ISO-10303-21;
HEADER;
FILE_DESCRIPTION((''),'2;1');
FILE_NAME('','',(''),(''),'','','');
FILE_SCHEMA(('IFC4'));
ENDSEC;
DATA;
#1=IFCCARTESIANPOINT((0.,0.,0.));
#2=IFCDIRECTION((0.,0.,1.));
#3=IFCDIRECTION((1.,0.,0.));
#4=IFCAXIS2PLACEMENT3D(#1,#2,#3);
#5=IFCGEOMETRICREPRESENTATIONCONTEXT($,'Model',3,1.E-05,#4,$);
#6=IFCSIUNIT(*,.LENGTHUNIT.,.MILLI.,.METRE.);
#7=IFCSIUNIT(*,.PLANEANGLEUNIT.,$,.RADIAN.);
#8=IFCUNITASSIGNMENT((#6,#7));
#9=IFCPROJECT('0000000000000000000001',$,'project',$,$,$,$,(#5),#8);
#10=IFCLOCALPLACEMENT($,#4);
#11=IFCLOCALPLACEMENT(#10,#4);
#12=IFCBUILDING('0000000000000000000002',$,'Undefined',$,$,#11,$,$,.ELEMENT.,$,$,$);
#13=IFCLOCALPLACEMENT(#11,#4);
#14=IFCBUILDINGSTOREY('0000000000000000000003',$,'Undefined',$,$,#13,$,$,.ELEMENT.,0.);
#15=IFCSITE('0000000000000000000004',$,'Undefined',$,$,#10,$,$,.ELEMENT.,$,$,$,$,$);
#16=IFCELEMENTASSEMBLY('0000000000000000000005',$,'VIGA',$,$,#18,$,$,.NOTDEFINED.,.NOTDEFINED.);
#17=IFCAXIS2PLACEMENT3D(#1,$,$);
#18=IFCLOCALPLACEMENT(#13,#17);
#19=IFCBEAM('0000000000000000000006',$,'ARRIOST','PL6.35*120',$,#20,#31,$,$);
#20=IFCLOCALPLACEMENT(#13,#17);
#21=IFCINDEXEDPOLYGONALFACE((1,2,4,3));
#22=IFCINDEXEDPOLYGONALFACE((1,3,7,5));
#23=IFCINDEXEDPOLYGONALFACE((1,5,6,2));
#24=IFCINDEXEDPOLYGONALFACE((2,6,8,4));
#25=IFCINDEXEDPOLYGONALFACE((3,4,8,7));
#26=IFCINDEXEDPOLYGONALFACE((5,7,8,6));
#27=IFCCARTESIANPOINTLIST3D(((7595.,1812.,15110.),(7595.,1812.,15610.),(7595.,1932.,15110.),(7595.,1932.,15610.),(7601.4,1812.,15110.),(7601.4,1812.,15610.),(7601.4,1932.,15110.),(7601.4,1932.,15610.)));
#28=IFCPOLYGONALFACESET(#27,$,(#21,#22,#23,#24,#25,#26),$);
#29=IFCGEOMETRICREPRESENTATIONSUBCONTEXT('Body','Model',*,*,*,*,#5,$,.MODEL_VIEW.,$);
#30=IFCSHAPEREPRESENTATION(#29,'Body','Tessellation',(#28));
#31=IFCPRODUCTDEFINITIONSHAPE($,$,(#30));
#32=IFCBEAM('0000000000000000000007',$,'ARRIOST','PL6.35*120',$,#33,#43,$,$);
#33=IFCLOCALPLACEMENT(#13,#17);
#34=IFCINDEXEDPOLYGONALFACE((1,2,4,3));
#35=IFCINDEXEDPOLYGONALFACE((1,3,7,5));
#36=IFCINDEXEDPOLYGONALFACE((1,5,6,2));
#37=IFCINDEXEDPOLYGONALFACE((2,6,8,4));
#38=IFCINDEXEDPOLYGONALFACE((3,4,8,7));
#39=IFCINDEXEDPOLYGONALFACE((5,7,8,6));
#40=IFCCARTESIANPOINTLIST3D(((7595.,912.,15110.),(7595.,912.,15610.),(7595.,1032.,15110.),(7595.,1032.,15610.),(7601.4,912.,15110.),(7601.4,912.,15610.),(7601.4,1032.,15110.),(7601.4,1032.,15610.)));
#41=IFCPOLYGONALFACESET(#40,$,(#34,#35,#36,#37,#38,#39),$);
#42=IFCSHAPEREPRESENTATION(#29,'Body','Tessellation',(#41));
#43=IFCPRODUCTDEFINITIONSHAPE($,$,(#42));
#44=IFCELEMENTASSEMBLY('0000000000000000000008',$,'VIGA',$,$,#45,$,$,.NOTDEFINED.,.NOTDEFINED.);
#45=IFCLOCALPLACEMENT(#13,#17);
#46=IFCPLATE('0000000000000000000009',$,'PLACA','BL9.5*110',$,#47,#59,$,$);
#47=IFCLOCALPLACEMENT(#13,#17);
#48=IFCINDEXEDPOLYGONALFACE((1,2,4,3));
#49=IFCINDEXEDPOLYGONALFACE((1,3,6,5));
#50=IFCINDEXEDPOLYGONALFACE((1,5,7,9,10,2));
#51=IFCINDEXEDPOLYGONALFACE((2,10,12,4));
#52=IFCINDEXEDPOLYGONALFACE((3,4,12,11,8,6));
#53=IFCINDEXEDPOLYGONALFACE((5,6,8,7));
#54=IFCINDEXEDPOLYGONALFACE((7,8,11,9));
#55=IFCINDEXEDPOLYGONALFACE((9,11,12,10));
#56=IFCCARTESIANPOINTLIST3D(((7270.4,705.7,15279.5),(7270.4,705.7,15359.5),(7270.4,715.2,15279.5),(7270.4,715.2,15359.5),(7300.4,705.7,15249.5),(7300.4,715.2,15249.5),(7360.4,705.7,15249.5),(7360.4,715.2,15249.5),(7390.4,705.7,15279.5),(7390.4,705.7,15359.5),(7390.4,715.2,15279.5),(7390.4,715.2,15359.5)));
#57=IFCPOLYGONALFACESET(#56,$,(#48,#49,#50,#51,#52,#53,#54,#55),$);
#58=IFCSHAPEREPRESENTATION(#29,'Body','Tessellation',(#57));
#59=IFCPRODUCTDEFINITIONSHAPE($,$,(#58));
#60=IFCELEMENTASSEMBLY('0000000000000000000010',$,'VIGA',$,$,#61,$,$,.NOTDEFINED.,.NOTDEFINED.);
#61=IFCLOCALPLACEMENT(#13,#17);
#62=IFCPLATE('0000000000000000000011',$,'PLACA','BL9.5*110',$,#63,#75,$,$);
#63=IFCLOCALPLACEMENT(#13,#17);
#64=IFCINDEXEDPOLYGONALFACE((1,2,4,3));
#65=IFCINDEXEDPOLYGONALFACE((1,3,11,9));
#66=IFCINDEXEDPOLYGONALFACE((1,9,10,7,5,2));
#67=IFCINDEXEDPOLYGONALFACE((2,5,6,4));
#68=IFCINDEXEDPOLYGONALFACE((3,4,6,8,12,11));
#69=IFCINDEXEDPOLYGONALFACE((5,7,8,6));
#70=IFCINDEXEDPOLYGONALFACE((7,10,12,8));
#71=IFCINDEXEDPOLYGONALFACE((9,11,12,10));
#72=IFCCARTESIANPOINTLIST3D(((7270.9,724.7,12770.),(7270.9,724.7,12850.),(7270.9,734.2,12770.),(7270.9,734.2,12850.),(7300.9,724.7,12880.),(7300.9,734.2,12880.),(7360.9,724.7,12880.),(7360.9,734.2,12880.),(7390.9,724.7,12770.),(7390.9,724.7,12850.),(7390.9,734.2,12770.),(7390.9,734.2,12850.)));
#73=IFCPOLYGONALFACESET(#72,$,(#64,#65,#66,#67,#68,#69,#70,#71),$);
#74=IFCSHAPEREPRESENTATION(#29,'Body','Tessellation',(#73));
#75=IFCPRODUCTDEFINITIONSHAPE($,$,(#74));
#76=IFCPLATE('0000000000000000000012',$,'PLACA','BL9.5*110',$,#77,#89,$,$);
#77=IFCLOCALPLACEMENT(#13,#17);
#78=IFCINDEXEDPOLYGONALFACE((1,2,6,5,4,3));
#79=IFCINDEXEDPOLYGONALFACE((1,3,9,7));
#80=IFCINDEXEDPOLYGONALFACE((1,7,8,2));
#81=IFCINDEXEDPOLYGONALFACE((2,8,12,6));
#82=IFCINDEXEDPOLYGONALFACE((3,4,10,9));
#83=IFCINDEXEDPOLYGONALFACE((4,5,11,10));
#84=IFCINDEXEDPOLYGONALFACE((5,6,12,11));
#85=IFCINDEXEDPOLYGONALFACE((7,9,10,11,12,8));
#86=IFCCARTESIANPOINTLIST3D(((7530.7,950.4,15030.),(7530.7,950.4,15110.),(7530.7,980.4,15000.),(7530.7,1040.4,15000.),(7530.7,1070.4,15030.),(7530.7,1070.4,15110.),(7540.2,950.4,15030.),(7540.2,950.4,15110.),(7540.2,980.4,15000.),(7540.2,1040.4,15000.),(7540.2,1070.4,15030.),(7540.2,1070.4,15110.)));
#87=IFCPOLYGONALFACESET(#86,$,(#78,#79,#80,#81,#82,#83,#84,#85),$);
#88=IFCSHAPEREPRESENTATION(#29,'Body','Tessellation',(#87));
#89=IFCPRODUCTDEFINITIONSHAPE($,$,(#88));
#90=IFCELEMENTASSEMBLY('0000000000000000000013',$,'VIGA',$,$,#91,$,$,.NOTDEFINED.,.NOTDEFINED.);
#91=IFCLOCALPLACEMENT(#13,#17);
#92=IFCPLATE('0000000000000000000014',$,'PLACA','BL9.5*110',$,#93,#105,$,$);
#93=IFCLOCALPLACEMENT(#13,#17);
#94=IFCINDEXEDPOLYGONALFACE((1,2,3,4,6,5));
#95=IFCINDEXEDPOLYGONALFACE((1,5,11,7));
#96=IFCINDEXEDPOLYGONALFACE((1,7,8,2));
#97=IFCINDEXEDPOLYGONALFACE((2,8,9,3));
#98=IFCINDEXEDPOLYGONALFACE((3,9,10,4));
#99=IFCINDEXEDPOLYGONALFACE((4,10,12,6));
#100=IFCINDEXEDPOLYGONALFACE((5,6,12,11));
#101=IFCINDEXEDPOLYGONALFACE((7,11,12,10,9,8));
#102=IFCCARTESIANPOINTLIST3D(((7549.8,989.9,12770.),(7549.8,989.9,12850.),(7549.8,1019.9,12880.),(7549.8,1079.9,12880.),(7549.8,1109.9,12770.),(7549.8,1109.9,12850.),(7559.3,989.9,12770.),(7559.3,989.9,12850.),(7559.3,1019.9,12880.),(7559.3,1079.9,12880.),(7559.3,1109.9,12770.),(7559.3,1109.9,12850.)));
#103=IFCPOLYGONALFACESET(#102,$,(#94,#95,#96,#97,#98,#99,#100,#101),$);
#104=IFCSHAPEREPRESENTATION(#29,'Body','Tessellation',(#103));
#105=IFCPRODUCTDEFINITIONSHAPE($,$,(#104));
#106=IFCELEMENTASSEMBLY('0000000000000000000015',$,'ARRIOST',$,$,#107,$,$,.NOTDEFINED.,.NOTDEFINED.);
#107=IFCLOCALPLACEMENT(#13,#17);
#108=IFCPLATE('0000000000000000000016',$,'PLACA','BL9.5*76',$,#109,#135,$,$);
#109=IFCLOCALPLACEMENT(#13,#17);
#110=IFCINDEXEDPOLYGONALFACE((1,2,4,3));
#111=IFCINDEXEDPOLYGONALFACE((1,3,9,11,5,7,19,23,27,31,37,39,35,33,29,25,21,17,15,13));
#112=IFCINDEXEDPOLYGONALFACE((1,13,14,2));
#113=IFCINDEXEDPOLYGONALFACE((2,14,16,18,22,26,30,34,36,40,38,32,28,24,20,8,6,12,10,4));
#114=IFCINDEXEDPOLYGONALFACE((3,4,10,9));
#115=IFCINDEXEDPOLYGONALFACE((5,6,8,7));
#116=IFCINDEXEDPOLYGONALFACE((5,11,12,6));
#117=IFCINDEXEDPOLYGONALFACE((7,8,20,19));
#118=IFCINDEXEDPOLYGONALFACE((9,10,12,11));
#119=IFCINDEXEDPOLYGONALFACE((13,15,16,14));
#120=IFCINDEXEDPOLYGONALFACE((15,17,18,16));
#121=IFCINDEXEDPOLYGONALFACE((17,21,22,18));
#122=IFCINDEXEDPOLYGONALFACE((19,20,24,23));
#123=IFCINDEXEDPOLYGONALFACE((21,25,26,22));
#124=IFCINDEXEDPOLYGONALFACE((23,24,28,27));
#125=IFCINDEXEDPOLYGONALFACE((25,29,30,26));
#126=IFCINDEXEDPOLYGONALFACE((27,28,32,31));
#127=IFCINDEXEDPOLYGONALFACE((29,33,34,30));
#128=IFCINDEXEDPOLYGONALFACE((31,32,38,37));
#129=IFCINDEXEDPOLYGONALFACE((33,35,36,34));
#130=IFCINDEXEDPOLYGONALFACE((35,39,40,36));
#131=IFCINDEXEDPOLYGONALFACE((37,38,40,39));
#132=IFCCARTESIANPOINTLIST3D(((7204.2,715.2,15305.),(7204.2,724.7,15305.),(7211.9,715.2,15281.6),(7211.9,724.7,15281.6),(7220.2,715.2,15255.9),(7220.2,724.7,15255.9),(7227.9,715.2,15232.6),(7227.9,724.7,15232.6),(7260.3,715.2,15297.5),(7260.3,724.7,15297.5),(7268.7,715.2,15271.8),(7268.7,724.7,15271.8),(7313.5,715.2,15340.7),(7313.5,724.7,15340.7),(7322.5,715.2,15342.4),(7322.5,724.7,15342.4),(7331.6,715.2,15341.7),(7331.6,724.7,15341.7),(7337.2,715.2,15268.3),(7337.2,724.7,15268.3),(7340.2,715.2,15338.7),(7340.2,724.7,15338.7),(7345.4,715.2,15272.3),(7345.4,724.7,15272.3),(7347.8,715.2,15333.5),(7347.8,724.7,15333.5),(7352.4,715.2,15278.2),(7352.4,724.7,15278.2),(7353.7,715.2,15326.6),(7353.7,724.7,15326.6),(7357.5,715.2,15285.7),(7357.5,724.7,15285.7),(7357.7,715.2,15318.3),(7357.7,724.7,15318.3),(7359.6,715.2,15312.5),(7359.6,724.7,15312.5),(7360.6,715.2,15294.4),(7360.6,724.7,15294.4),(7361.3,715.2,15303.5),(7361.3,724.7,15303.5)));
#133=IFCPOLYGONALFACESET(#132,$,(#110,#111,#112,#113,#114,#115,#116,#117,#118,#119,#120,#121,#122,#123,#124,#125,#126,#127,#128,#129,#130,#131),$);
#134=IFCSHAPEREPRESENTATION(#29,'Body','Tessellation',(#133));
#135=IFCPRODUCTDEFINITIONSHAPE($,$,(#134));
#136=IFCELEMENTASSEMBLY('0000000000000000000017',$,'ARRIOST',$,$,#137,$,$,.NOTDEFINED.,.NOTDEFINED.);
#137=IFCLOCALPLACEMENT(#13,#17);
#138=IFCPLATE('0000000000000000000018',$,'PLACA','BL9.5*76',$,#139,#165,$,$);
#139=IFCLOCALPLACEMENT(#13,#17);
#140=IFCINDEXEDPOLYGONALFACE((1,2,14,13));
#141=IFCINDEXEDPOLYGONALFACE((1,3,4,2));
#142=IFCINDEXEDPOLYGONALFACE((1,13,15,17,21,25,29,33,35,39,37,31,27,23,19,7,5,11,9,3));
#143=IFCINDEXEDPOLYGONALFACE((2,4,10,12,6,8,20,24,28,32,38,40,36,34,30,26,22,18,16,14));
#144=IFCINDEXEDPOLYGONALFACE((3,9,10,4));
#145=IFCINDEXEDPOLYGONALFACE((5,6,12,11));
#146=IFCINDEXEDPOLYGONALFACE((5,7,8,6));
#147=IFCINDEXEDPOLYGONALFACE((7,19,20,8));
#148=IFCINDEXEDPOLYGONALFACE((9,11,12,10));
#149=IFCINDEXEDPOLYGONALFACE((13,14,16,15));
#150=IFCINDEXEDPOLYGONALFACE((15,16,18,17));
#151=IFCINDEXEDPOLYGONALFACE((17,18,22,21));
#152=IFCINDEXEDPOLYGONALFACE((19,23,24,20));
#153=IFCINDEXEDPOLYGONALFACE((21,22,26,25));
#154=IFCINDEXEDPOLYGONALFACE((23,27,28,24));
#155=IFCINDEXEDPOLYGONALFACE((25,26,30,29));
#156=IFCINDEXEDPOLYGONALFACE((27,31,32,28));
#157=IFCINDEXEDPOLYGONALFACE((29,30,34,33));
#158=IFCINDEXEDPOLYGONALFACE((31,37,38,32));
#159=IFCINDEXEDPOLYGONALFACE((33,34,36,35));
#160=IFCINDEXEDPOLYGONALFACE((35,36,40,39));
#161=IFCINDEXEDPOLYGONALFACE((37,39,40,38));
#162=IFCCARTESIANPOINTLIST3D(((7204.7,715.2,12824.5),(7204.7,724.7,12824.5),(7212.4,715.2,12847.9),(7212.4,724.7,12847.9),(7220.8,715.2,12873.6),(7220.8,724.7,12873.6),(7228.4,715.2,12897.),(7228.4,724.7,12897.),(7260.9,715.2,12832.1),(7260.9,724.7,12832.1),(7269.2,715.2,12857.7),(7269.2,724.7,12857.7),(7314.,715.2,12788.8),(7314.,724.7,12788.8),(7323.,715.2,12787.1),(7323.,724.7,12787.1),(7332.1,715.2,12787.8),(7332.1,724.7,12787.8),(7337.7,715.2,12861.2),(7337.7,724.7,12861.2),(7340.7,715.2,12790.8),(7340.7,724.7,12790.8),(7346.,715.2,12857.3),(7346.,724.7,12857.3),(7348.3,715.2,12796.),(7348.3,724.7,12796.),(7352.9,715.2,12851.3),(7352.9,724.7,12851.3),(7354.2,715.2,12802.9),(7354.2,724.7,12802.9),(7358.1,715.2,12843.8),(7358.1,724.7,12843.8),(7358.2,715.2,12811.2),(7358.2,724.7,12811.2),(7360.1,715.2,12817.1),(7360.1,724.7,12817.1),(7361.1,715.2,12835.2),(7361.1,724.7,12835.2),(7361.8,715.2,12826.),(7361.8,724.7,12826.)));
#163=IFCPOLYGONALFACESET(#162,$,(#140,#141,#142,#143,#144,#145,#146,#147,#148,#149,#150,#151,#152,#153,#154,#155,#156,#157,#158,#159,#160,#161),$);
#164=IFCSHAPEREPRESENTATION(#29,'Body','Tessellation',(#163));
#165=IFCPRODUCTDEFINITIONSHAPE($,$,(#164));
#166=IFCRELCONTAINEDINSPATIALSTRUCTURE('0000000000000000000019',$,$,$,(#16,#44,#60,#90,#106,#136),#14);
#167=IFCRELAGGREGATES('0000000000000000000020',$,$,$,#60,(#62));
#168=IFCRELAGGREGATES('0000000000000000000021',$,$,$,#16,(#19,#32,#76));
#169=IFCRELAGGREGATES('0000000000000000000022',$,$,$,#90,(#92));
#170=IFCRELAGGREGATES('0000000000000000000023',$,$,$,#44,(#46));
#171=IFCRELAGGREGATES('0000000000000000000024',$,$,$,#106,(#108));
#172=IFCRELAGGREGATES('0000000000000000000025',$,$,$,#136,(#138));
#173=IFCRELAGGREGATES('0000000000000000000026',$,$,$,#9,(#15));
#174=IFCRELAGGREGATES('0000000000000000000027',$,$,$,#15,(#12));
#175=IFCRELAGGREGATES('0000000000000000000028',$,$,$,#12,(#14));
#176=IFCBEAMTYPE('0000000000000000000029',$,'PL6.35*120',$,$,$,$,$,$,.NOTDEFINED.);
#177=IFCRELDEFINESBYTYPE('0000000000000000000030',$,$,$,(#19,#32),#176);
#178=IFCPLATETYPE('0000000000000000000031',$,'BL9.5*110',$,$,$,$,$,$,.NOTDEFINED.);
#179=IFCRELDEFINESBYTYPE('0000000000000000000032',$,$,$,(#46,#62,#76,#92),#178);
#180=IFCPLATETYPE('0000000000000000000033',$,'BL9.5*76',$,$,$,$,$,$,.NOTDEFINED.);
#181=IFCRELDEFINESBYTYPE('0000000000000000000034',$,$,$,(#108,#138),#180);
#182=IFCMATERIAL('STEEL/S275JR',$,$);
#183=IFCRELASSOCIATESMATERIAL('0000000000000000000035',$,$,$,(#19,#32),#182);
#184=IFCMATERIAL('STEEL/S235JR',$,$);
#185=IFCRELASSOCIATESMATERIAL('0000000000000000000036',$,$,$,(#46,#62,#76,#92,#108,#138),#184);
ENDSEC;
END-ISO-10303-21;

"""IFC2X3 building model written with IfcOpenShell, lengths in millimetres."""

from ifc_helpers import new_model, si_unit, frame, frame_2d, origin_with_axes, origin_2d_with_axis, place, context, subcontext, project, spatial, polyline, circle_curve, parameter, trimmed, segment, composite_curve, rectangle, outline, extrude, boolean, material, type_object, element, aggregate, save


model = new_model("IFC2X3")

# Units and contexts
model_context = context("Model", 3, precision=1e-05, world=origin_with_axes())
body_context = subcontext(model_context, "Body", "Model", "MODEL_VIEW")
ifc_project = project(units=[si_unit("LENGTHUNIT", "METRE", prefix="MILLI"), si_unit("PLANEANGLEUNIT", "RADIAN")], contexts=[model_context])

# Site, building, storey
site_placement = place(None, origin_with_axes())
site = spatial("IfcSite", under=ifc_project, at=site_placement, Name="Undefined", CompositionType="ELEMENT")
building_placement = place(site_placement, origin_with_axes())
building = spatial("IfcBuilding", under=site, at=building_placement, Name="Undefined", CompositionType="ELEMENT")
storey_placement = place(building_placement, origin_with_axes())
storey = spatial("IfcBuildingStorey", under=building, at=storey_placement, Name="Undefined", CompositionType="ELEMENT", Elevation=0.0)

# Element assembly, beams
assembly_1_placement = place(storey_placement, origin_with_axes())
assembly_1 = element("IfcElementAssembly", 1, at=assembly_1_placement, inside=storey, Name="VIGA", AssemblyPlace="NOTDEFINED", PredefinedType="NOTDEFINED")
ifc_material_1 = material(Name="STEEL/S275JR")
beam_type = type_object("IfcBeamType", Name="PL6.35*120", PredefinedType="NOTDEFINED")
beam_1_placement = place(assembly_1_placement, frame((7598.2, 1872.0, 15110.0), z_axis=(0.0, 1.0, 0.0), x_axis=(0.0, 0.0, 1.0)))
beam_1 = element("IfcBeam", 2, at=beam_1_placement, type_object=beam_type, material=ifc_material_1, Name="ARRIOST", Description="PL6.35*120", context=body_context, shape_type="SweptSolid", body=[
    extrude(rectangle(XDim=6.3, YDim=120.0, at=origin_2d_with_axis()), frame((500.0, 0.0, 0.0), z_axis=(-1.0, 0.0, 0.0), x_axis=(0.0, -1.0, 0.0)), (0.0, 0.0, 1.0), 500.0),
])
beam_2_placement = place(assembly_1_placement, frame((7598.2, 972.0, 15110.0), z_axis=(0.0, 1.0, 0.0), x_axis=(0.0, 0.0, 1.0)))
beam_2 = element("IfcBeam", 3, at=beam_2_placement, type_object=beam_type, material=ifc_material_1, Name="ARRIOST", Description="PL6.35*120", context=body_context, shape_type="SweptSolid", body=[
    extrude(rectangle(XDim=6.3, YDim=120.0, at=origin_2d_with_axis()), frame((500.0, 0.0, 0.0), z_axis=(-1.0, 0.0, 0.0), x_axis=(0.0, -1.0, 0.0)), (0.0, 0.0, 1.0), 500.0),
])

# Element assemblies, plates
assembly_2_placement = place(storey_placement, origin_with_axes())
assembly_2 = element("IfcElementAssembly", 4, at=assembly_2_placement, inside=storey, Name="VIGA", AssemblyPlace="NOTDEFINED", PredefinedType="NOTDEFINED")
ifc_material_2 = material(Name="STEEL/S235JR")
plate_type_1 = type_object("IfcPlateType", Name="BL9.5*110", PredefinedType="NOTDEFINED")
plate_1_placement = place(assembly_2_placement, frame((7270.4, 710.5, 15279.5), z_axis=(0.0, 1.0, 0.0), x_axis=(0.0, 0.0, 1.0)))
plate_1 = element("IfcPlate", 5, at=plate_1_placement, type_object=plate_type_1, material=ifc_material_2, Name="PLACA", Description="BL9.5*110", context=body_context, shape_type="SweptSolid", body=[
    extrude(outline(polyline([(0.0, 0.0), (80.0, 0.0), (80.0, 120.0), (0.0, 120.0), (-30.0, 90.0), (-30.0, 30.0), (0.0, 0.0)])), frame((0.0, 0.0, -4.7), z_axis=(0.0, 0.0, 1.0), x_axis=(1.0, 0.0, 0.0)), (0.0, 0.0, 1.0), 9.5),
])
assembly_3_placement = place(storey_placement, origin_with_axes())
assembly_3 = element("IfcElementAssembly", 6, at=assembly_3_placement, inside=storey, Name="VIGA", AssemblyPlace="NOTDEFINED", PredefinedType="NOTDEFINED")
plate_2_placement = place(assembly_3_placement, frame((7270.9, 729.5, 12850.0), z_axis=(0.0, -1.0, 0.0), x_axis=(0.0, 0.0, -1.0)))
plate_2 = element("IfcPlate", 7, at=plate_2_placement, type_object=plate_type_1, material=ifc_material_2, Name="PLACA", Description="BL9.5*110", context=body_context, shape_type="SweptSolid", body=[
    extrude(outline(polyline([(0.0, 0.0), (80.0, 0.0), (80.0, 120.0), (0.0, 120.0), (-30.0, 90.0), (-30.0, 30.0), (0.0, 0.0)])), frame((0.0, 0.0, -4.7), z_axis=(0.0, 0.0, 1.0), x_axis=(1.0, 0.0, 0.0)), (0.0, 0.0, 1.0), 9.5),
])
aggregate(assembly_3, [plate_2])

# Plate
plate_3_placement = place(assembly_1_placement, frame((7535.5, 1070.4, 15030.0), z_axis=(1.0, 0.0, 0.0), x_axis=(0.0, 0.0, 1.0)))
plate_3 = element("IfcPlate", 8, at=plate_3_placement, type_object=plate_type_1, material=ifc_material_2, Name="PLACA", Description="BL9.5*110", context=body_context, shape_type="SweptSolid", body=[
    extrude(outline(polyline([(0.0, 0.0), (80.0, 0.0), (80.0, 120.0), (0.0, 120.0), (-30.0, 90.0), (-30.0, 30.0), (0.0, 0.0)])), frame((0.0, 0.0, -4.7), z_axis=(0.0, 0.0, 1.0), x_axis=(1.0, 0.0, 0.0)), (0.0, 0.0, 1.0), 9.5),
])
aggregate(assembly_1, [beam_1, beam_2, plate_3])

# Element assemblies, plates
assembly_4_placement = place(storey_placement, origin_with_axes())
assembly_4 = element("IfcElementAssembly", 9, at=assembly_4_placement, inside=storey, Name="VIGA", AssemblyPlace="NOTDEFINED", PredefinedType="NOTDEFINED")
plate_4_placement = place(assembly_4_placement, frame((7554.5, 1109.9, 12850.0), z_axis=(-1.0, 0.0, 0.0), x_axis=(0.0, 0.0, -1.0)))
plate_4 = element("IfcPlate", 10, at=plate_4_placement, type_object=plate_type_1, material=ifc_material_2, Name="PLACA", Description="BL9.5*110", context=body_context, shape_type="SweptSolid", body=[
    extrude(outline(polyline([(0.0, 0.0), (80.0, 0.0), (80.0, 120.0), (0.0, 120.0), (-30.0, 90.0), (-30.0, 30.0), (0.0, 0.0)])), frame((0.0, 0.0, -4.7), z_axis=(0.0, 0.0, 1.0), x_axis=(1.0, 0.0, 0.0)), (0.0, 0.0, 1.0), 9.5),
])
aggregate(assembly_4, [plate_4])
assembly_5_placement = place(storey_placement, origin_with_axes())
assembly_5 = element("IfcElementAssembly", 11, at=assembly_5_placement, inside=storey, Name="ARRIOST", AssemblyPlace="NOTDEFINED", PredefinedType="NOTDEFINED")
plate_type_2 = type_object("IfcPlateType", Name="BL9.5*76", PredefinedType="NOTDEFINED")
plate_5_placement = place(assembly_5_placement, frame((7346.8, 720.0, 15351.6), z_axis=(0.0, 1.0, 0.0), x_axis=(0.310822, 0.0, -0.950468)))
plate_5 = element("IfcPlate", 12, at=plate_5_placement, type_object=plate_type_2, material=ifc_material_2, Name="PLACA", Description="BL9.5*76", context=body_context, shape_type="CSG", body=[
    boolean("DIFFERENCE", extrude(outline(composite_curve([segment(trimmed(circle_curve(frame_2d((35.0, 35.0), x_axis=(-1.0, 0.0)), 35.0), [parameter(0.0)], [parameter(1.570796)], True, "PARAMETER"), True, "CONTINUOUS"), segment(polyline([(35.0, 0.0), (41.2, 0.0)]), True, "CONTINUOUS"), segment(trimmed(circle_curve(frame_2d((41.2, 35.0), x_axis=(0.0, -1.0)), 35.0), [parameter(0.0)], [parameter(1.570796)], True, "PARAMETER"), True, "CONTINUOUS"), segment(polyline([(76.2, 35.0), (76.2, 150.0), (0.0, 150.0), (0.0, 35.0)]), True, "CONTINUOUS")], self_intersect=True)), frame((0.0, 0.0, -4.7), z_axis=(0.0, 0.0, 1.0), x_axis=(1.0, 0.0, 0.0)), (0.0, 0.0, 1.0), 9.5), extrude(rectangle(XDim=27.0, YDim=27.0, at=origin_2d_with_axis()), frame((38.1, 250.0, 0.0), z_axis=(0.0, -1.0, 0.0), x_axis=(-1.0, 0.0, 0.0)), (0.0, 0.0, 1.0), 151.0)),
])
assembly_6_placement = place(storey_placement, origin_with_axes())
assembly_6 = element("IfcElementAssembly", 13, at=assembly_6_placement, inside=storey, Name="ARRIOST", AssemblyPlace="NOTDEFINED", PredefinedType="NOTDEFINED")
plate_6_placement = place(assembly_6_placement, frame((7347.3, 720.0, 12777.9), z_axis=(0.0, -1.0, 0.0), x_axis=(0.310857, 0.0, 0.950457)))
plate_6 = element("IfcPlate", 14, at=plate_6_placement, type_object=plate_type_2, material=ifc_material_2, Name="PLACA", Description="BL9.5*76", context=body_context, shape_type="CSG", body=[
    boolean("DIFFERENCE", extrude(outline(composite_curve([segment(trimmed(circle_curve(frame_2d((35.0, 35.0), x_axis=(-1.0, 0.0)), 35.0), [parameter(0.0)], [parameter(1.570796)], True, "PARAMETER"), True, "CONTINUOUS"), segment(polyline([(35.0, 0.0), (41.2, 0.0)]), True, "CONTINUOUS"), segment(trimmed(circle_curve(frame_2d((41.2, 35.0), x_axis=(0.0, -1.0)), 35.0), [parameter(0.0)], [parameter(1.570796)], True, "PARAMETER"), True, "CONTINUOUS"), segment(polyline([(76.2, 35.0), (76.2, 150.0), (0.0, 150.0), (0.0, 35.0)]), True, "CONTINUOUS")], self_intersect=True)), frame((0.0, 0.0, -4.7), z_axis=(0.0, 0.0, 1.0), x_axis=(1.0, 0.0, 0.0)), (0.0, 0.0, 1.0), 9.5), extrude(rectangle(XDim=27.0, YDim=27.0, at=origin_2d_with_axis()), frame((38.1, 250.0, 0.0), z_axis=(0.0, -1.0, 0.0), x_axis=(1.0, 0.0, 0.0)), (0.0, 0.0, 1.0), 151.0)),
])

aggregate(assembly_2, [plate_1])

aggregate(assembly_5, [plate_5])
aggregate(assembly_6, [plate_6])

save(model, "model.ifc")
